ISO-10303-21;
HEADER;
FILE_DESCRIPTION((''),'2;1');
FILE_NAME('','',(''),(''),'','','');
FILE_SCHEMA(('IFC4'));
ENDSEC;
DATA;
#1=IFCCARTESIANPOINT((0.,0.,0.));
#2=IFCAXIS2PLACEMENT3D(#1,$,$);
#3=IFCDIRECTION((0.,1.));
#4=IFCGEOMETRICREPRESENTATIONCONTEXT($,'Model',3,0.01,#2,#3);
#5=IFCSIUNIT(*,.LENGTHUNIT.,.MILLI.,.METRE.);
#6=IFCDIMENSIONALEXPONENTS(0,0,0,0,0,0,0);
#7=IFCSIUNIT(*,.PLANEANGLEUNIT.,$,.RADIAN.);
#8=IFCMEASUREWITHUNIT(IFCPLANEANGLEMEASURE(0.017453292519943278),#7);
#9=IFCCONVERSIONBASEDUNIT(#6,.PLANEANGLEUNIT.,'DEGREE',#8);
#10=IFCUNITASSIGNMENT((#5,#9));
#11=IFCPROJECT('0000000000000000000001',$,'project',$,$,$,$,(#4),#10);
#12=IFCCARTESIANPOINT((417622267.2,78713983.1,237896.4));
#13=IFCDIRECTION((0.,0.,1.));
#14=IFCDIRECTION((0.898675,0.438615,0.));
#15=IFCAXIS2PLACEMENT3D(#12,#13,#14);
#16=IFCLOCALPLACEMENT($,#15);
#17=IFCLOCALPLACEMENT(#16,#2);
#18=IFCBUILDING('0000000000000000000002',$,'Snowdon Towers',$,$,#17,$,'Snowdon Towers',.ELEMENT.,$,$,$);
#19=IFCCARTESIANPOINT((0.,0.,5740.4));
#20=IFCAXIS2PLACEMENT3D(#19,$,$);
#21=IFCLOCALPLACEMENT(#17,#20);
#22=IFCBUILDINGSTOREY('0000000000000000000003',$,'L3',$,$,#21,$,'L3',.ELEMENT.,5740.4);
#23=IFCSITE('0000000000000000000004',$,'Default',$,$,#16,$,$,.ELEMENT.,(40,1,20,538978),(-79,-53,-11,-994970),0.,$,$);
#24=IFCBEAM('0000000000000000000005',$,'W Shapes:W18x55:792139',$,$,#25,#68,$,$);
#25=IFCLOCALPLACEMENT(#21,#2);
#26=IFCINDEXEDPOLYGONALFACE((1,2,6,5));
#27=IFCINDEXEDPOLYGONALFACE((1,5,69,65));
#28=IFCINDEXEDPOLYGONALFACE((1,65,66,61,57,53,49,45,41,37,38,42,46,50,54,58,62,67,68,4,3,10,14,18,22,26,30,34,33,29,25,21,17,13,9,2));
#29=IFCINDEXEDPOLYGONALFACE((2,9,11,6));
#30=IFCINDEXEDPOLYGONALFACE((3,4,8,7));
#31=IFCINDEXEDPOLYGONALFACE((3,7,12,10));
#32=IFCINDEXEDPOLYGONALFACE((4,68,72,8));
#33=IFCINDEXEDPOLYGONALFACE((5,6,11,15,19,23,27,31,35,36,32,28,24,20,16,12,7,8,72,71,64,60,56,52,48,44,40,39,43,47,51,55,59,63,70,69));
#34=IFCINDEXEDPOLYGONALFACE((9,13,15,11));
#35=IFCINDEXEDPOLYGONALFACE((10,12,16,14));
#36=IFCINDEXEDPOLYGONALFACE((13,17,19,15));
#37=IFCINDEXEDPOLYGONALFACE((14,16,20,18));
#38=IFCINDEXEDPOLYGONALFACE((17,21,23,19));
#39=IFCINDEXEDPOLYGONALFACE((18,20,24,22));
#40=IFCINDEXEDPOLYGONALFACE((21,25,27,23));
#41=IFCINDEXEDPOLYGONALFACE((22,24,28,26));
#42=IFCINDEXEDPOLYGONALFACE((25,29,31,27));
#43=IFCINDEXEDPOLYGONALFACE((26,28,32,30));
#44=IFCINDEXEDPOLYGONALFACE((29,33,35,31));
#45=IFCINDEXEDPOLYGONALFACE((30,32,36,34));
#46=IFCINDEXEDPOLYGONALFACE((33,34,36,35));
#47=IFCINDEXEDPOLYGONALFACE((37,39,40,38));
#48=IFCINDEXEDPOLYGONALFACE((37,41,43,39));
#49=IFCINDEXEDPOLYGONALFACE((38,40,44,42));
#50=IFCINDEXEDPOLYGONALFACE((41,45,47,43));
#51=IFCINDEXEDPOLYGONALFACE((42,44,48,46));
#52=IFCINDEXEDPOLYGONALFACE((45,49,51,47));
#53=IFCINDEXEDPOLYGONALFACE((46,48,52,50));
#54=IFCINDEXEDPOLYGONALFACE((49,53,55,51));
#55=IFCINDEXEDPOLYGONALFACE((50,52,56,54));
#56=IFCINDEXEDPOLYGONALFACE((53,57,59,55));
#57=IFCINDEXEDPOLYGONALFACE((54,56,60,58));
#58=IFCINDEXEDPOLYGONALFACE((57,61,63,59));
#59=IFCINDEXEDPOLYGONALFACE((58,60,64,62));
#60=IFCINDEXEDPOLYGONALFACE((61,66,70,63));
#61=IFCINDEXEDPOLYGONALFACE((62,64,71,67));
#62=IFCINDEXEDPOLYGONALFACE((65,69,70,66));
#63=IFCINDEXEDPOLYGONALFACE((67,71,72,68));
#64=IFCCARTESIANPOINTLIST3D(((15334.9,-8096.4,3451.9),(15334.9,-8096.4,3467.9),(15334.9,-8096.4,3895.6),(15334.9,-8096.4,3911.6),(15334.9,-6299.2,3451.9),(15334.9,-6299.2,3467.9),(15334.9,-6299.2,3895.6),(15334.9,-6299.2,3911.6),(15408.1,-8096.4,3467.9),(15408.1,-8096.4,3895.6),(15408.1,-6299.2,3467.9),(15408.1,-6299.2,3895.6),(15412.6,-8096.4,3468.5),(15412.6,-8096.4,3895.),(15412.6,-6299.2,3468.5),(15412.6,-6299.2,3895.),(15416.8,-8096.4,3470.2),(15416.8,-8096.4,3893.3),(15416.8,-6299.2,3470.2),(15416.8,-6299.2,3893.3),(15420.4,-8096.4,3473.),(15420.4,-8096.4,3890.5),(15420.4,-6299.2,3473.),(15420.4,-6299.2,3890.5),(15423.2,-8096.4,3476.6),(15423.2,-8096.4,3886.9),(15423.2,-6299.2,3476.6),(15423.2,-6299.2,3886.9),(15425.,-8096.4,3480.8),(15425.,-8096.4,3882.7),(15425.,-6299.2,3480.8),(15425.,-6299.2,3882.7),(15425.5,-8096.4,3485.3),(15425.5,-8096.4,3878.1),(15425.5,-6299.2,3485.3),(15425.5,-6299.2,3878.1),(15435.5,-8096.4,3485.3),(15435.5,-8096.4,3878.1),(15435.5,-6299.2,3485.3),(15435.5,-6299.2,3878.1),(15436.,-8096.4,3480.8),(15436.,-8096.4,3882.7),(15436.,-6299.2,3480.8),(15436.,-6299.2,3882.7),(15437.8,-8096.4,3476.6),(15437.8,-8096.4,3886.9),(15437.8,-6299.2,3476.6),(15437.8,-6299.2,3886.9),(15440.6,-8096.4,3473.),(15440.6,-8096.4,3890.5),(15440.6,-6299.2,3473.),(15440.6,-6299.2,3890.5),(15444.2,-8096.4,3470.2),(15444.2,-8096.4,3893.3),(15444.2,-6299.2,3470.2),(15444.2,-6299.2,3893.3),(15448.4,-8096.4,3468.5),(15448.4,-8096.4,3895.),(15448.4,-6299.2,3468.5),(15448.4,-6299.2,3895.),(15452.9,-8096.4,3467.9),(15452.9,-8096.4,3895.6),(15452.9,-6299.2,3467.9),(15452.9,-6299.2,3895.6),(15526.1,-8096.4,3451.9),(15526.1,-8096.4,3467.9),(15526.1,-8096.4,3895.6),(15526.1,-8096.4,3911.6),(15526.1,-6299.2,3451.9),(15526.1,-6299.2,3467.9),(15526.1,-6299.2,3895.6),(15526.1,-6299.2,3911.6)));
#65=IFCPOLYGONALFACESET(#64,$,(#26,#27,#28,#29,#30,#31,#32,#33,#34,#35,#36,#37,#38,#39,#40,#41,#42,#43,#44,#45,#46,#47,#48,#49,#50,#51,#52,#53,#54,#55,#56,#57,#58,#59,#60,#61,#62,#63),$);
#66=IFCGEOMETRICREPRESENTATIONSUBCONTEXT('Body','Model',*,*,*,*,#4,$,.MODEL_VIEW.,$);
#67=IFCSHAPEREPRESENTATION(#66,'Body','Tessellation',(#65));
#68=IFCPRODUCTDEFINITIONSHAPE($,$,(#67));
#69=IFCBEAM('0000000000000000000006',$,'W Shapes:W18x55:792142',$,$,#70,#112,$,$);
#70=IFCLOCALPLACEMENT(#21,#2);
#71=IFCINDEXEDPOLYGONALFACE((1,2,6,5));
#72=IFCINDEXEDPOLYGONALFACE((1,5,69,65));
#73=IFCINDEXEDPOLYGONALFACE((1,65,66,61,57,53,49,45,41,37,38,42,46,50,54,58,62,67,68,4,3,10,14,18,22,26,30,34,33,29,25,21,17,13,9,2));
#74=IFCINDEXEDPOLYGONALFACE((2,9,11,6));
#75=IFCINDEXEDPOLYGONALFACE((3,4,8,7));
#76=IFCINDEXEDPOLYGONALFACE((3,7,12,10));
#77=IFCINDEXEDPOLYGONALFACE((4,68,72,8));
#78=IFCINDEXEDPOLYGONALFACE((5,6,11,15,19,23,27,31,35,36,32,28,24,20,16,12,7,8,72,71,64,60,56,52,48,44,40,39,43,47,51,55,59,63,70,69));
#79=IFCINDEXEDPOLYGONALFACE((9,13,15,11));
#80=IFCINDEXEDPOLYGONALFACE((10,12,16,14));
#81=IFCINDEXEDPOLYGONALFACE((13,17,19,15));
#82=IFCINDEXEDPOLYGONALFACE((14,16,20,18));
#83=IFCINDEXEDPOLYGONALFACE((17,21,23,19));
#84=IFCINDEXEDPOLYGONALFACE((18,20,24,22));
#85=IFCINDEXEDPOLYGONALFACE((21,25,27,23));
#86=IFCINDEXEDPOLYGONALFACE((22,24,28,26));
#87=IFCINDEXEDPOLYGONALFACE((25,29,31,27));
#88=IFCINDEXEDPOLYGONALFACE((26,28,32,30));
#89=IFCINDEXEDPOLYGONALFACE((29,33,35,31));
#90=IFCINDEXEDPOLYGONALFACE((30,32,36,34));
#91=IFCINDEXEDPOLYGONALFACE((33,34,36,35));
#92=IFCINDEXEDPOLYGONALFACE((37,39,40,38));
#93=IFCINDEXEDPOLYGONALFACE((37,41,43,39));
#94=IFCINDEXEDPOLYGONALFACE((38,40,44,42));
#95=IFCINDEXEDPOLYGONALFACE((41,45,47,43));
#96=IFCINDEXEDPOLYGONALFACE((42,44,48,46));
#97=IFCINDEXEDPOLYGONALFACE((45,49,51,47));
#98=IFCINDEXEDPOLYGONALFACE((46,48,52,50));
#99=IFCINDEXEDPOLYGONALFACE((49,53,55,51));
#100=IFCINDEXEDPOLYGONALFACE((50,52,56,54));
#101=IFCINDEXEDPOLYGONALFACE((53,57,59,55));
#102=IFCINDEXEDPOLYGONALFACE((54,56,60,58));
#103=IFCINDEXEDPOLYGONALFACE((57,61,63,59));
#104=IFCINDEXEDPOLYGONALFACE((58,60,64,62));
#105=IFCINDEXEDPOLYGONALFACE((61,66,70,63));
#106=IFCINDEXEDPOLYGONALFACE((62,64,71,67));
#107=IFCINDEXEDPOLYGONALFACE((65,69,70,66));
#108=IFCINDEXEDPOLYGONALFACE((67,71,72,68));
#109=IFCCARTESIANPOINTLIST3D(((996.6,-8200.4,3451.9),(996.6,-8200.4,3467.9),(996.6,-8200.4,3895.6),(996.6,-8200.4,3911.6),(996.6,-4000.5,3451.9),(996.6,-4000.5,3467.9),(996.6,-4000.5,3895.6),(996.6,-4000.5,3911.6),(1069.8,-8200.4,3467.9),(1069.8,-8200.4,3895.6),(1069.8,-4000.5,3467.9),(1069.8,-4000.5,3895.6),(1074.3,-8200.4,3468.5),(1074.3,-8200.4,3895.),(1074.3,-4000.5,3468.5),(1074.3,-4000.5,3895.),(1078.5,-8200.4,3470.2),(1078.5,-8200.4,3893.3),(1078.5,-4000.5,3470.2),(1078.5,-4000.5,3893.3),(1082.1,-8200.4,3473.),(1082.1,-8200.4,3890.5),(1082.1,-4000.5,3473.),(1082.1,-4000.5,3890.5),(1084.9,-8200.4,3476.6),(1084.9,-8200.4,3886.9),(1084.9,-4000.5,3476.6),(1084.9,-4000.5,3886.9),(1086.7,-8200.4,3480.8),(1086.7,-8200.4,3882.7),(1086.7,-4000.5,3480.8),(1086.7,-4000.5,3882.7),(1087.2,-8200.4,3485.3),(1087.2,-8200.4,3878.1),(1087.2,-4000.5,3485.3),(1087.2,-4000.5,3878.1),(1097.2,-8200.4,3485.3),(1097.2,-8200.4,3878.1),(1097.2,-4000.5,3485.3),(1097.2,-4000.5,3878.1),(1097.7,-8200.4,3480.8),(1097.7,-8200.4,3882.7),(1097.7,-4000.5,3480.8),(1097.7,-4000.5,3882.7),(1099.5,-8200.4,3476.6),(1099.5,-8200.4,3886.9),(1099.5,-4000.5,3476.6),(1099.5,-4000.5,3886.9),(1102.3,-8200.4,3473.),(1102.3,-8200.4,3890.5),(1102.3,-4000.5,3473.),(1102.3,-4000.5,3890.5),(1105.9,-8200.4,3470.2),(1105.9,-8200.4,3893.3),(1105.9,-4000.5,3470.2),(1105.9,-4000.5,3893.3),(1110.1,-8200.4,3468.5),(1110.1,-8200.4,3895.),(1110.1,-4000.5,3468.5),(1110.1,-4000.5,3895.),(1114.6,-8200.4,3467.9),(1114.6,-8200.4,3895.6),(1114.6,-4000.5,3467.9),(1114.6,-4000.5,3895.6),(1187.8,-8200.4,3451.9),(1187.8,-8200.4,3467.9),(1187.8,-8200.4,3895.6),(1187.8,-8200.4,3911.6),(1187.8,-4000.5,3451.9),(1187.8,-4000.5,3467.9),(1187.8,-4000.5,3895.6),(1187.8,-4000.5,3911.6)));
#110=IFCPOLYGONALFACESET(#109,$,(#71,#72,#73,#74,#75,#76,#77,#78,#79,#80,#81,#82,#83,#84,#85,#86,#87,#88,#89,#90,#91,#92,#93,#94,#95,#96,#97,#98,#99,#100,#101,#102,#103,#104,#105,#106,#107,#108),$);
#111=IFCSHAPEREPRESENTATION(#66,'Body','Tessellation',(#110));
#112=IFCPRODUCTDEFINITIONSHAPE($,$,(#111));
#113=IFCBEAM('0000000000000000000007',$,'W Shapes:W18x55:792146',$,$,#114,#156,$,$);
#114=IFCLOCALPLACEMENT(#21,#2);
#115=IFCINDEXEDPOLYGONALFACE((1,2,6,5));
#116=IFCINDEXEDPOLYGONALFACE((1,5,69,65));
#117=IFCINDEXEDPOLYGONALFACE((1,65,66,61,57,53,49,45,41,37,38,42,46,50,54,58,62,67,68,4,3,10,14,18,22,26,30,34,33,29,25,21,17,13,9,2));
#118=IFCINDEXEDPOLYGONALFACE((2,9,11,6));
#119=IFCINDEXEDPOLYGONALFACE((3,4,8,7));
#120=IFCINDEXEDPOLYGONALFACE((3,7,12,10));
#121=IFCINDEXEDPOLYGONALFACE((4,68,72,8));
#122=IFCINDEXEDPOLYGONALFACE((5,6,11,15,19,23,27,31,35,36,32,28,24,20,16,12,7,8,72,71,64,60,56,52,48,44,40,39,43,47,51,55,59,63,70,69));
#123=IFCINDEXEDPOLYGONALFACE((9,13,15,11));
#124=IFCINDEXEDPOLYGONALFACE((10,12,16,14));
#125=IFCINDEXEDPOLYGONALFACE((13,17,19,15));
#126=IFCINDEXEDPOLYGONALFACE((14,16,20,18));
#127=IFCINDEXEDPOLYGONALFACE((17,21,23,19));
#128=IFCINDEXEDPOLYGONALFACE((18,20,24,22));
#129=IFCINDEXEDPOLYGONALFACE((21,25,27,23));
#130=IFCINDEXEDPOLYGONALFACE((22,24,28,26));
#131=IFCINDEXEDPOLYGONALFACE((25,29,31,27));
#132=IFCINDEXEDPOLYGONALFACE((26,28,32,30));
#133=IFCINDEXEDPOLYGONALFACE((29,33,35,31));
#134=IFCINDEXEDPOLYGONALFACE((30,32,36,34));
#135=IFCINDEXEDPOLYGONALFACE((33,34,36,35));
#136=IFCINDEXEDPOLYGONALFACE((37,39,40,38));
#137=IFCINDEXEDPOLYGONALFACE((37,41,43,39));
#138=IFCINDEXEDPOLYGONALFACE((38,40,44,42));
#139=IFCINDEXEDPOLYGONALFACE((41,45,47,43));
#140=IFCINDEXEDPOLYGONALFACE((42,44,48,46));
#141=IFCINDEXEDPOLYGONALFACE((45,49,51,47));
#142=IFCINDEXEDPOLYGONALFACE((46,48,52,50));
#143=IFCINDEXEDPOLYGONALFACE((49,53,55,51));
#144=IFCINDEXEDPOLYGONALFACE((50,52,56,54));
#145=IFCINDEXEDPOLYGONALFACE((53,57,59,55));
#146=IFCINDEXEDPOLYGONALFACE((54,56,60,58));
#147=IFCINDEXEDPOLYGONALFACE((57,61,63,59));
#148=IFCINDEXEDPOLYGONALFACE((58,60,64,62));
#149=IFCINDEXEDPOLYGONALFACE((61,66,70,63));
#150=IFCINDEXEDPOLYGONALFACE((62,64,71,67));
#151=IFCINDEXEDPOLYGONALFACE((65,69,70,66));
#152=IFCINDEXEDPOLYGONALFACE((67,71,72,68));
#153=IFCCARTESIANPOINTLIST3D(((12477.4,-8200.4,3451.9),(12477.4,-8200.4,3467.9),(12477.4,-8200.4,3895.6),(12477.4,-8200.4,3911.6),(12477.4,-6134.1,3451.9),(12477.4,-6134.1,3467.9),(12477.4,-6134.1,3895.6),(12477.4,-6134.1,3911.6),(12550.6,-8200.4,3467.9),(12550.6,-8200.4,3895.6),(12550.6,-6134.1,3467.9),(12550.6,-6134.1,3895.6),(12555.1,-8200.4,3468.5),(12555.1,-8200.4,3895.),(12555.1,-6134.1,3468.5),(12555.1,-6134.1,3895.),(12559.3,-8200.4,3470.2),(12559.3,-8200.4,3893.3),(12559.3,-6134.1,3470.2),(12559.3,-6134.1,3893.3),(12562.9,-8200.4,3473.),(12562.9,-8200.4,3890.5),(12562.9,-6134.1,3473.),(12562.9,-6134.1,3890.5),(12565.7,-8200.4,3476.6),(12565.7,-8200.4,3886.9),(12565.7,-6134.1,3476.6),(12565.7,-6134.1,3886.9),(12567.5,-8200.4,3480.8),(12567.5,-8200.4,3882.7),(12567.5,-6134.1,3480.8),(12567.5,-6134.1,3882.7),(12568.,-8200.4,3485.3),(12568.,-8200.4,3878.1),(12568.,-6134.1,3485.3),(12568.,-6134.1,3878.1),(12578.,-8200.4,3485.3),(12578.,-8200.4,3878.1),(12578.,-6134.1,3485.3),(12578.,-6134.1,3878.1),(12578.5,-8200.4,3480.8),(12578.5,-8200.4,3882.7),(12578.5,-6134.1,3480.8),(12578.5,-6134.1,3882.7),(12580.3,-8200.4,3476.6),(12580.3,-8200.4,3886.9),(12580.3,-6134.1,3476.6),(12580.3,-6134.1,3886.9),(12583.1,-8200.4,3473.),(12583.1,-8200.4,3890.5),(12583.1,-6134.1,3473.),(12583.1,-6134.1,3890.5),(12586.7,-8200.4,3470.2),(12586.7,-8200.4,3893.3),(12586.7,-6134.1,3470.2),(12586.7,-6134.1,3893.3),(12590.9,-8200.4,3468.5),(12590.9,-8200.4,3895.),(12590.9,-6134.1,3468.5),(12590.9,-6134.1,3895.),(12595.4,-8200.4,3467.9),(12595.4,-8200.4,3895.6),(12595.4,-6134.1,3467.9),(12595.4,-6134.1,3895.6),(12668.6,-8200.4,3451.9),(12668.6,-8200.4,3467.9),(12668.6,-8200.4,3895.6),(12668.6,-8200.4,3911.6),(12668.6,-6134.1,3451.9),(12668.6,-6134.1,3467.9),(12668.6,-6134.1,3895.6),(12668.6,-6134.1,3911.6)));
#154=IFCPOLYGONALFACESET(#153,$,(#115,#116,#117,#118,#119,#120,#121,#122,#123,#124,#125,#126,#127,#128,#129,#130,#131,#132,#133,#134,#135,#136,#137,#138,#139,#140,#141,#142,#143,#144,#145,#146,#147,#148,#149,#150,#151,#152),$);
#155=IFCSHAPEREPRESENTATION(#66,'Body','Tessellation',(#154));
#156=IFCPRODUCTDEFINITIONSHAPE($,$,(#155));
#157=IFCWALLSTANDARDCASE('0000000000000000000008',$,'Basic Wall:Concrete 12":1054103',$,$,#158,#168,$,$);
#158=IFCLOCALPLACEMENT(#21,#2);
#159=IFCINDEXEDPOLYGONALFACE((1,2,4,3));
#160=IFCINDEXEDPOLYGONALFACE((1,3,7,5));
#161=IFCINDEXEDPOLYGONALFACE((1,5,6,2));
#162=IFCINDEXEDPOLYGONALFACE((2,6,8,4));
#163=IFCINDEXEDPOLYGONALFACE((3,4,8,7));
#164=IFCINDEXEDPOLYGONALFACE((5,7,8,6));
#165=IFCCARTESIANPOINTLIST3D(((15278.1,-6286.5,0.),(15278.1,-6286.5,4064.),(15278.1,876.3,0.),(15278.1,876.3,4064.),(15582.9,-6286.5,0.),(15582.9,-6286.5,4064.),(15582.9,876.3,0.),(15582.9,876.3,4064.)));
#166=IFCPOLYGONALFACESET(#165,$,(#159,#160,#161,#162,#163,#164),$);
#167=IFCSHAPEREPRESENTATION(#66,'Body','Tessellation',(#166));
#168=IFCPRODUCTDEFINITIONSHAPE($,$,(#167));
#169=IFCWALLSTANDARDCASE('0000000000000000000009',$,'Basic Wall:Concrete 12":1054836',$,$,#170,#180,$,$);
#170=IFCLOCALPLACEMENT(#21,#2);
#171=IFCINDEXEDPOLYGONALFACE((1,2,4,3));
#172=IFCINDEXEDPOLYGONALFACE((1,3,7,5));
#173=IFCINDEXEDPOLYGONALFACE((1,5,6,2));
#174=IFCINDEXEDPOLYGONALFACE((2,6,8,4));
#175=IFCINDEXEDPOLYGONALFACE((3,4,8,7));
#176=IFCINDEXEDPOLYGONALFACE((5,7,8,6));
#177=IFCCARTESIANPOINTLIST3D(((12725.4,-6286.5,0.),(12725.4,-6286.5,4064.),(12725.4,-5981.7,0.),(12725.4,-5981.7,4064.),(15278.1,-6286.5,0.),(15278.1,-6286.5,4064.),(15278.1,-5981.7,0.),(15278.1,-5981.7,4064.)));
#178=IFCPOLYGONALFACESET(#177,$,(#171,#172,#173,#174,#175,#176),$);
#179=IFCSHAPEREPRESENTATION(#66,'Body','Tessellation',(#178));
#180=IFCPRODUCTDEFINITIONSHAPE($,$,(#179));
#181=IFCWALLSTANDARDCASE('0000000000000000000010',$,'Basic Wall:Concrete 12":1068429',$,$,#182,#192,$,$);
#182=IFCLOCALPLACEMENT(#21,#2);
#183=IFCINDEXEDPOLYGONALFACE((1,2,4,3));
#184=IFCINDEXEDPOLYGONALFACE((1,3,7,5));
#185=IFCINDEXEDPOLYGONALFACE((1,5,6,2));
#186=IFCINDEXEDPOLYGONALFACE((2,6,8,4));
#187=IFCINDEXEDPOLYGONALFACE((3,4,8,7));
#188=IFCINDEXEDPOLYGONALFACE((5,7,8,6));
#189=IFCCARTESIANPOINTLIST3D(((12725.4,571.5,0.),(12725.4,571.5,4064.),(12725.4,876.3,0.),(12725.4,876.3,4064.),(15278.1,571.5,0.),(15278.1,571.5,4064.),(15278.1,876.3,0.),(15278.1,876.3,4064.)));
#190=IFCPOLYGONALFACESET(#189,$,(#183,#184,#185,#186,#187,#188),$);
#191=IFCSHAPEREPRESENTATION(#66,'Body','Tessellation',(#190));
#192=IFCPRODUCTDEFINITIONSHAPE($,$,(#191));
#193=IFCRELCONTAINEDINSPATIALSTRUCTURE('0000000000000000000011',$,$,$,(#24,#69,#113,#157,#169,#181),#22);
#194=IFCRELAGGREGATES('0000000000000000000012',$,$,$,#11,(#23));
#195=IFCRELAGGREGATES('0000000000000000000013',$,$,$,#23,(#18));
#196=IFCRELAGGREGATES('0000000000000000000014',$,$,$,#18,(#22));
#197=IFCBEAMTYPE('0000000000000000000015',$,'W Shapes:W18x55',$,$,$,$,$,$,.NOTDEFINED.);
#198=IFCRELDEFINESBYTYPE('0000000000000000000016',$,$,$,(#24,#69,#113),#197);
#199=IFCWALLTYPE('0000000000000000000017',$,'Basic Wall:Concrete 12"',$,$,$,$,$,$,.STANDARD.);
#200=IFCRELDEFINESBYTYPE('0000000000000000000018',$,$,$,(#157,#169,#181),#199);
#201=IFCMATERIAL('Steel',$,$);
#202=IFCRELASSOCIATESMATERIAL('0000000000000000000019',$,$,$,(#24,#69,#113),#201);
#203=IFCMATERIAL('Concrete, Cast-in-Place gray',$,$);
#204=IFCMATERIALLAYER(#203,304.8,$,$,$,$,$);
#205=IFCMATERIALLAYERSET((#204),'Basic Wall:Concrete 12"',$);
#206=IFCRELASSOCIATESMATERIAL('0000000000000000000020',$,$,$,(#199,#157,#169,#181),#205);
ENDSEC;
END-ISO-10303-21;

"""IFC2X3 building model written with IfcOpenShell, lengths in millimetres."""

from ifc_helpers import new_model, entity, si_unit, converted_unit, direction, frame, frame_2d, origin, place, context, subcontext, project, spatial, rectangle, i_section, extrude, material, layer, layer_set, layer_usage, type_object, element, save


model = new_model("IFC2X3")

# Units and contexts
model_context = context("Model", 3, precision=0.01, world=origin(), true_north=direction((0.0, 1.0)))
body_context = subcontext(model_context, "Body", "Model", "MODEL_VIEW")
ifc_project = project(units=[si_unit("LENGTHUNIT", "METRE", prefix="MILLI"), converted_unit("PLANEANGLEUNIT", "DEGREE", entity("IfcPlaneAngleMeasure", 0.017453292519943278), si_unit("PLANEANGLEUNIT", "RADIAN"), dimensions=[0, 0, 0, 0, 0, 0, 0])], contexts=[model_context])

# Site, building, storey
site_placement = place(None, frame((417622267.2, 78713983.1, 237896.4), z_axis=(0.0, 0.0, 1.0), x_axis=(0.898675, 0.438615, 0.0)))
site = spatial("IfcSite", under=ifc_project, at=site_placement, Name="Default", CompositionType="ELEMENT", RefLatitude=(40, 1, 20, 538978), RefLongitude=(-79, -53, -11, -994970), RefElevation=0.0)
building_placement = place(site_placement, origin())
building = spatial("IfcBuilding", under=site, at=building_placement, Name="Snowdon Towers", LongName="Snowdon Towers", CompositionType="ELEMENT")
storey_placement = place(building_placement, frame((0.0, 0.0, 5740.4)))
storey = spatial("IfcBuildingStorey", under=building, at=storey_placement, Name="L3", LongName="L3", CompositionType="ELEMENT", Elevation=5740.4)

# Shared definitions
ifc_material_1 = material(Name="Steel")

# Beams
beam_type_1 = type_object("IfcBeamType", Name="W Shapes:W18x55", PredefinedType="NOTDEFINED")
beam_1_placement = place(storey_placement, frame((15430.5, -6134.1, 3911.6), z_axis=(0.0, 0.0, 1.0), x_axis=(0.0, -1.0, 0.0)))
element("IfcBeam", 1, at=beam_1_placement, inside=storey, type_object=beam_type_1, material=ifc_material_1, Name="W Shapes:W18x55:792139", context=body_context, shape_type="SweptSolid", body=[
    extrude(i_section(OverallWidth=191.3, OverallDepth=459.7, WebThickness=9.9, FlangeThickness=16.0, FilletRadius=17.5, at=frame_2d((0.0, 0.0), x_axis=(0.0, 1.0))), frame((165.1, 0.0, -229.9), z_axis=(1.0, 0.0, 0.0), x_axis=(0.0, 0.0, -1.0)), (0.0, 0.0, 1.0), 1797.2),
])
beam_2_placement = place(storey_placement, frame((1092.2, -3873.5, 3911.6), z_axis=(0.0, 0.0, 1.0), x_axis=(0.0, -1.0, 0.0)))
element("IfcBeam", 2, at=beam_2_placement, inside=storey, type_object=beam_type_1, material=ifc_material_1, Name="W Shapes:W18x55:792142", context=body_context, shape_type="SweptSolid", body=[
    extrude(i_section(OverallWidth=191.3, OverallDepth=459.7, WebThickness=9.9, FlangeThickness=16.0, FilletRadius=17.5, at=frame_2d((0.0, 0.0), x_axis=(0.0, 1.0))), frame((127.0, 0.0, -229.9), z_axis=(1.0, 0.0, 0.0), x_axis=(0.0, 0.0, -1.0)), (0.0, 0.0, 1.0), 4199.9),
])
beam_3_placement = place(storey_placement, frame((12573.0, -6134.1, 3911.6), z_axis=(0.0, 0.0, 1.0), x_axis=(0.0, -1.0, 0.0)))
element("IfcBeam", 3, at=beam_3_placement, inside=storey, type_object=beam_type_1, material=ifc_material_1, Name="W Shapes:W18x55:792146", context=body_context, shape_type="SweptSolid", body=[
    extrude(i_section(OverallWidth=191.3, OverallDepth=459.7, WebThickness=9.9, FlangeThickness=16.0, FilletRadius=17.5, at=frame_2d((0.0, 0.0), x_axis=(0.0, 1.0))), frame((0.0, 0.0, -229.9), z_axis=(1.0, 0.0, 0.0), x_axis=(0.0, 0.0, -1.0)), (0.0, 0.0, 1.0), 2066.3),
])

# Walls
ifc_material_2 = material(Name="Concrete, Cast-in-Place gray")
ifc_layer = layer(ifc_material_2, 304.8)
ifc_layer_set = layer_set([ifc_layer], Name="Basic Wall:Concrete 12\"")
ifc_layer_usage_1 = layer_usage(ifc_layer_set, "AXIS2", "NEGATIVE", 152.4)
wall_type = type_object("IfcWallType", Name="Basic Wall:Concrete 12\"", PredefinedType="STANDARD", material=ifc_layer_set)
wall_1_placement = place(storey_placement, frame((15430.5, -6286.5, 0.0), z_axis=(0.0, 0.0, 1.0), x_axis=(0.0, 1.0, 0.0)))
element("IfcWallStandardCase", 4, at=wall_1_placement, inside=storey, type_object=wall_type, material=ifc_layer_usage_1, Name="Basic Wall:Concrete 12\":1054103", context=body_context, shape_type="SweptSolid", body=[
    extrude(rectangle(XDim=7162.8, YDim=304.8, at=frame_2d((3581.4, 0.0), x_axis=(-1.0, 0.0))), origin(), (0.0, 0.0, 1.0), 4064.0),
])
ifc_layer_usage_2 = layer_usage(ifc_layer_set, "AXIS2", "POSITIVE", -152.4)
wall_2_placement = place(storey_placement, frame((15278.1, -6134.1, 0.0), z_axis=(0.0, 0.0, 1.0), x_axis=(-1.0, 0.0, 0.0)))
element("IfcWallStandardCase", 5, at=wall_2_placement, inside=storey, type_object=wall_type, material=ifc_layer_usage_2, Name="Basic Wall:Concrete 12\":1054836", context=body_context, shape_type="SweptSolid", body=[
    extrude(rectangle(XDim=2552.7, YDim=304.8, at=frame_2d((1276.3, 0.0), x_axis=(-1.0, 0.0))), origin(), (0.0, 0.0, 1.0), 4064.0),
])
ifc_layer_usage_3 = layer_usage(ifc_layer_set, "AXIS2", "POSITIVE", -152.4)
wall_3_placement = place(storey_placement, frame((15278.1, 723.9, 0.0), z_axis=(0.0, 0.0, 1.0), x_axis=(-1.0, 0.0, 0.0)))
element("IfcWallStandardCase", 6, at=wall_3_placement, inside=storey, type_object=wall_type, material=ifc_layer_usage_3, Name="Basic Wall:Concrete 12\":1068429", context=body_context, shape_type="SweptSolid", body=[
    extrude(rectangle(XDim=2552.7, YDim=304.8, at=frame_2d((1276.3, 0.0), x_axis=(-1.0, 0.0))), origin(), (0.0, 0.0, 1.0), 4064.0),
])

save(model, "model.ifc")
